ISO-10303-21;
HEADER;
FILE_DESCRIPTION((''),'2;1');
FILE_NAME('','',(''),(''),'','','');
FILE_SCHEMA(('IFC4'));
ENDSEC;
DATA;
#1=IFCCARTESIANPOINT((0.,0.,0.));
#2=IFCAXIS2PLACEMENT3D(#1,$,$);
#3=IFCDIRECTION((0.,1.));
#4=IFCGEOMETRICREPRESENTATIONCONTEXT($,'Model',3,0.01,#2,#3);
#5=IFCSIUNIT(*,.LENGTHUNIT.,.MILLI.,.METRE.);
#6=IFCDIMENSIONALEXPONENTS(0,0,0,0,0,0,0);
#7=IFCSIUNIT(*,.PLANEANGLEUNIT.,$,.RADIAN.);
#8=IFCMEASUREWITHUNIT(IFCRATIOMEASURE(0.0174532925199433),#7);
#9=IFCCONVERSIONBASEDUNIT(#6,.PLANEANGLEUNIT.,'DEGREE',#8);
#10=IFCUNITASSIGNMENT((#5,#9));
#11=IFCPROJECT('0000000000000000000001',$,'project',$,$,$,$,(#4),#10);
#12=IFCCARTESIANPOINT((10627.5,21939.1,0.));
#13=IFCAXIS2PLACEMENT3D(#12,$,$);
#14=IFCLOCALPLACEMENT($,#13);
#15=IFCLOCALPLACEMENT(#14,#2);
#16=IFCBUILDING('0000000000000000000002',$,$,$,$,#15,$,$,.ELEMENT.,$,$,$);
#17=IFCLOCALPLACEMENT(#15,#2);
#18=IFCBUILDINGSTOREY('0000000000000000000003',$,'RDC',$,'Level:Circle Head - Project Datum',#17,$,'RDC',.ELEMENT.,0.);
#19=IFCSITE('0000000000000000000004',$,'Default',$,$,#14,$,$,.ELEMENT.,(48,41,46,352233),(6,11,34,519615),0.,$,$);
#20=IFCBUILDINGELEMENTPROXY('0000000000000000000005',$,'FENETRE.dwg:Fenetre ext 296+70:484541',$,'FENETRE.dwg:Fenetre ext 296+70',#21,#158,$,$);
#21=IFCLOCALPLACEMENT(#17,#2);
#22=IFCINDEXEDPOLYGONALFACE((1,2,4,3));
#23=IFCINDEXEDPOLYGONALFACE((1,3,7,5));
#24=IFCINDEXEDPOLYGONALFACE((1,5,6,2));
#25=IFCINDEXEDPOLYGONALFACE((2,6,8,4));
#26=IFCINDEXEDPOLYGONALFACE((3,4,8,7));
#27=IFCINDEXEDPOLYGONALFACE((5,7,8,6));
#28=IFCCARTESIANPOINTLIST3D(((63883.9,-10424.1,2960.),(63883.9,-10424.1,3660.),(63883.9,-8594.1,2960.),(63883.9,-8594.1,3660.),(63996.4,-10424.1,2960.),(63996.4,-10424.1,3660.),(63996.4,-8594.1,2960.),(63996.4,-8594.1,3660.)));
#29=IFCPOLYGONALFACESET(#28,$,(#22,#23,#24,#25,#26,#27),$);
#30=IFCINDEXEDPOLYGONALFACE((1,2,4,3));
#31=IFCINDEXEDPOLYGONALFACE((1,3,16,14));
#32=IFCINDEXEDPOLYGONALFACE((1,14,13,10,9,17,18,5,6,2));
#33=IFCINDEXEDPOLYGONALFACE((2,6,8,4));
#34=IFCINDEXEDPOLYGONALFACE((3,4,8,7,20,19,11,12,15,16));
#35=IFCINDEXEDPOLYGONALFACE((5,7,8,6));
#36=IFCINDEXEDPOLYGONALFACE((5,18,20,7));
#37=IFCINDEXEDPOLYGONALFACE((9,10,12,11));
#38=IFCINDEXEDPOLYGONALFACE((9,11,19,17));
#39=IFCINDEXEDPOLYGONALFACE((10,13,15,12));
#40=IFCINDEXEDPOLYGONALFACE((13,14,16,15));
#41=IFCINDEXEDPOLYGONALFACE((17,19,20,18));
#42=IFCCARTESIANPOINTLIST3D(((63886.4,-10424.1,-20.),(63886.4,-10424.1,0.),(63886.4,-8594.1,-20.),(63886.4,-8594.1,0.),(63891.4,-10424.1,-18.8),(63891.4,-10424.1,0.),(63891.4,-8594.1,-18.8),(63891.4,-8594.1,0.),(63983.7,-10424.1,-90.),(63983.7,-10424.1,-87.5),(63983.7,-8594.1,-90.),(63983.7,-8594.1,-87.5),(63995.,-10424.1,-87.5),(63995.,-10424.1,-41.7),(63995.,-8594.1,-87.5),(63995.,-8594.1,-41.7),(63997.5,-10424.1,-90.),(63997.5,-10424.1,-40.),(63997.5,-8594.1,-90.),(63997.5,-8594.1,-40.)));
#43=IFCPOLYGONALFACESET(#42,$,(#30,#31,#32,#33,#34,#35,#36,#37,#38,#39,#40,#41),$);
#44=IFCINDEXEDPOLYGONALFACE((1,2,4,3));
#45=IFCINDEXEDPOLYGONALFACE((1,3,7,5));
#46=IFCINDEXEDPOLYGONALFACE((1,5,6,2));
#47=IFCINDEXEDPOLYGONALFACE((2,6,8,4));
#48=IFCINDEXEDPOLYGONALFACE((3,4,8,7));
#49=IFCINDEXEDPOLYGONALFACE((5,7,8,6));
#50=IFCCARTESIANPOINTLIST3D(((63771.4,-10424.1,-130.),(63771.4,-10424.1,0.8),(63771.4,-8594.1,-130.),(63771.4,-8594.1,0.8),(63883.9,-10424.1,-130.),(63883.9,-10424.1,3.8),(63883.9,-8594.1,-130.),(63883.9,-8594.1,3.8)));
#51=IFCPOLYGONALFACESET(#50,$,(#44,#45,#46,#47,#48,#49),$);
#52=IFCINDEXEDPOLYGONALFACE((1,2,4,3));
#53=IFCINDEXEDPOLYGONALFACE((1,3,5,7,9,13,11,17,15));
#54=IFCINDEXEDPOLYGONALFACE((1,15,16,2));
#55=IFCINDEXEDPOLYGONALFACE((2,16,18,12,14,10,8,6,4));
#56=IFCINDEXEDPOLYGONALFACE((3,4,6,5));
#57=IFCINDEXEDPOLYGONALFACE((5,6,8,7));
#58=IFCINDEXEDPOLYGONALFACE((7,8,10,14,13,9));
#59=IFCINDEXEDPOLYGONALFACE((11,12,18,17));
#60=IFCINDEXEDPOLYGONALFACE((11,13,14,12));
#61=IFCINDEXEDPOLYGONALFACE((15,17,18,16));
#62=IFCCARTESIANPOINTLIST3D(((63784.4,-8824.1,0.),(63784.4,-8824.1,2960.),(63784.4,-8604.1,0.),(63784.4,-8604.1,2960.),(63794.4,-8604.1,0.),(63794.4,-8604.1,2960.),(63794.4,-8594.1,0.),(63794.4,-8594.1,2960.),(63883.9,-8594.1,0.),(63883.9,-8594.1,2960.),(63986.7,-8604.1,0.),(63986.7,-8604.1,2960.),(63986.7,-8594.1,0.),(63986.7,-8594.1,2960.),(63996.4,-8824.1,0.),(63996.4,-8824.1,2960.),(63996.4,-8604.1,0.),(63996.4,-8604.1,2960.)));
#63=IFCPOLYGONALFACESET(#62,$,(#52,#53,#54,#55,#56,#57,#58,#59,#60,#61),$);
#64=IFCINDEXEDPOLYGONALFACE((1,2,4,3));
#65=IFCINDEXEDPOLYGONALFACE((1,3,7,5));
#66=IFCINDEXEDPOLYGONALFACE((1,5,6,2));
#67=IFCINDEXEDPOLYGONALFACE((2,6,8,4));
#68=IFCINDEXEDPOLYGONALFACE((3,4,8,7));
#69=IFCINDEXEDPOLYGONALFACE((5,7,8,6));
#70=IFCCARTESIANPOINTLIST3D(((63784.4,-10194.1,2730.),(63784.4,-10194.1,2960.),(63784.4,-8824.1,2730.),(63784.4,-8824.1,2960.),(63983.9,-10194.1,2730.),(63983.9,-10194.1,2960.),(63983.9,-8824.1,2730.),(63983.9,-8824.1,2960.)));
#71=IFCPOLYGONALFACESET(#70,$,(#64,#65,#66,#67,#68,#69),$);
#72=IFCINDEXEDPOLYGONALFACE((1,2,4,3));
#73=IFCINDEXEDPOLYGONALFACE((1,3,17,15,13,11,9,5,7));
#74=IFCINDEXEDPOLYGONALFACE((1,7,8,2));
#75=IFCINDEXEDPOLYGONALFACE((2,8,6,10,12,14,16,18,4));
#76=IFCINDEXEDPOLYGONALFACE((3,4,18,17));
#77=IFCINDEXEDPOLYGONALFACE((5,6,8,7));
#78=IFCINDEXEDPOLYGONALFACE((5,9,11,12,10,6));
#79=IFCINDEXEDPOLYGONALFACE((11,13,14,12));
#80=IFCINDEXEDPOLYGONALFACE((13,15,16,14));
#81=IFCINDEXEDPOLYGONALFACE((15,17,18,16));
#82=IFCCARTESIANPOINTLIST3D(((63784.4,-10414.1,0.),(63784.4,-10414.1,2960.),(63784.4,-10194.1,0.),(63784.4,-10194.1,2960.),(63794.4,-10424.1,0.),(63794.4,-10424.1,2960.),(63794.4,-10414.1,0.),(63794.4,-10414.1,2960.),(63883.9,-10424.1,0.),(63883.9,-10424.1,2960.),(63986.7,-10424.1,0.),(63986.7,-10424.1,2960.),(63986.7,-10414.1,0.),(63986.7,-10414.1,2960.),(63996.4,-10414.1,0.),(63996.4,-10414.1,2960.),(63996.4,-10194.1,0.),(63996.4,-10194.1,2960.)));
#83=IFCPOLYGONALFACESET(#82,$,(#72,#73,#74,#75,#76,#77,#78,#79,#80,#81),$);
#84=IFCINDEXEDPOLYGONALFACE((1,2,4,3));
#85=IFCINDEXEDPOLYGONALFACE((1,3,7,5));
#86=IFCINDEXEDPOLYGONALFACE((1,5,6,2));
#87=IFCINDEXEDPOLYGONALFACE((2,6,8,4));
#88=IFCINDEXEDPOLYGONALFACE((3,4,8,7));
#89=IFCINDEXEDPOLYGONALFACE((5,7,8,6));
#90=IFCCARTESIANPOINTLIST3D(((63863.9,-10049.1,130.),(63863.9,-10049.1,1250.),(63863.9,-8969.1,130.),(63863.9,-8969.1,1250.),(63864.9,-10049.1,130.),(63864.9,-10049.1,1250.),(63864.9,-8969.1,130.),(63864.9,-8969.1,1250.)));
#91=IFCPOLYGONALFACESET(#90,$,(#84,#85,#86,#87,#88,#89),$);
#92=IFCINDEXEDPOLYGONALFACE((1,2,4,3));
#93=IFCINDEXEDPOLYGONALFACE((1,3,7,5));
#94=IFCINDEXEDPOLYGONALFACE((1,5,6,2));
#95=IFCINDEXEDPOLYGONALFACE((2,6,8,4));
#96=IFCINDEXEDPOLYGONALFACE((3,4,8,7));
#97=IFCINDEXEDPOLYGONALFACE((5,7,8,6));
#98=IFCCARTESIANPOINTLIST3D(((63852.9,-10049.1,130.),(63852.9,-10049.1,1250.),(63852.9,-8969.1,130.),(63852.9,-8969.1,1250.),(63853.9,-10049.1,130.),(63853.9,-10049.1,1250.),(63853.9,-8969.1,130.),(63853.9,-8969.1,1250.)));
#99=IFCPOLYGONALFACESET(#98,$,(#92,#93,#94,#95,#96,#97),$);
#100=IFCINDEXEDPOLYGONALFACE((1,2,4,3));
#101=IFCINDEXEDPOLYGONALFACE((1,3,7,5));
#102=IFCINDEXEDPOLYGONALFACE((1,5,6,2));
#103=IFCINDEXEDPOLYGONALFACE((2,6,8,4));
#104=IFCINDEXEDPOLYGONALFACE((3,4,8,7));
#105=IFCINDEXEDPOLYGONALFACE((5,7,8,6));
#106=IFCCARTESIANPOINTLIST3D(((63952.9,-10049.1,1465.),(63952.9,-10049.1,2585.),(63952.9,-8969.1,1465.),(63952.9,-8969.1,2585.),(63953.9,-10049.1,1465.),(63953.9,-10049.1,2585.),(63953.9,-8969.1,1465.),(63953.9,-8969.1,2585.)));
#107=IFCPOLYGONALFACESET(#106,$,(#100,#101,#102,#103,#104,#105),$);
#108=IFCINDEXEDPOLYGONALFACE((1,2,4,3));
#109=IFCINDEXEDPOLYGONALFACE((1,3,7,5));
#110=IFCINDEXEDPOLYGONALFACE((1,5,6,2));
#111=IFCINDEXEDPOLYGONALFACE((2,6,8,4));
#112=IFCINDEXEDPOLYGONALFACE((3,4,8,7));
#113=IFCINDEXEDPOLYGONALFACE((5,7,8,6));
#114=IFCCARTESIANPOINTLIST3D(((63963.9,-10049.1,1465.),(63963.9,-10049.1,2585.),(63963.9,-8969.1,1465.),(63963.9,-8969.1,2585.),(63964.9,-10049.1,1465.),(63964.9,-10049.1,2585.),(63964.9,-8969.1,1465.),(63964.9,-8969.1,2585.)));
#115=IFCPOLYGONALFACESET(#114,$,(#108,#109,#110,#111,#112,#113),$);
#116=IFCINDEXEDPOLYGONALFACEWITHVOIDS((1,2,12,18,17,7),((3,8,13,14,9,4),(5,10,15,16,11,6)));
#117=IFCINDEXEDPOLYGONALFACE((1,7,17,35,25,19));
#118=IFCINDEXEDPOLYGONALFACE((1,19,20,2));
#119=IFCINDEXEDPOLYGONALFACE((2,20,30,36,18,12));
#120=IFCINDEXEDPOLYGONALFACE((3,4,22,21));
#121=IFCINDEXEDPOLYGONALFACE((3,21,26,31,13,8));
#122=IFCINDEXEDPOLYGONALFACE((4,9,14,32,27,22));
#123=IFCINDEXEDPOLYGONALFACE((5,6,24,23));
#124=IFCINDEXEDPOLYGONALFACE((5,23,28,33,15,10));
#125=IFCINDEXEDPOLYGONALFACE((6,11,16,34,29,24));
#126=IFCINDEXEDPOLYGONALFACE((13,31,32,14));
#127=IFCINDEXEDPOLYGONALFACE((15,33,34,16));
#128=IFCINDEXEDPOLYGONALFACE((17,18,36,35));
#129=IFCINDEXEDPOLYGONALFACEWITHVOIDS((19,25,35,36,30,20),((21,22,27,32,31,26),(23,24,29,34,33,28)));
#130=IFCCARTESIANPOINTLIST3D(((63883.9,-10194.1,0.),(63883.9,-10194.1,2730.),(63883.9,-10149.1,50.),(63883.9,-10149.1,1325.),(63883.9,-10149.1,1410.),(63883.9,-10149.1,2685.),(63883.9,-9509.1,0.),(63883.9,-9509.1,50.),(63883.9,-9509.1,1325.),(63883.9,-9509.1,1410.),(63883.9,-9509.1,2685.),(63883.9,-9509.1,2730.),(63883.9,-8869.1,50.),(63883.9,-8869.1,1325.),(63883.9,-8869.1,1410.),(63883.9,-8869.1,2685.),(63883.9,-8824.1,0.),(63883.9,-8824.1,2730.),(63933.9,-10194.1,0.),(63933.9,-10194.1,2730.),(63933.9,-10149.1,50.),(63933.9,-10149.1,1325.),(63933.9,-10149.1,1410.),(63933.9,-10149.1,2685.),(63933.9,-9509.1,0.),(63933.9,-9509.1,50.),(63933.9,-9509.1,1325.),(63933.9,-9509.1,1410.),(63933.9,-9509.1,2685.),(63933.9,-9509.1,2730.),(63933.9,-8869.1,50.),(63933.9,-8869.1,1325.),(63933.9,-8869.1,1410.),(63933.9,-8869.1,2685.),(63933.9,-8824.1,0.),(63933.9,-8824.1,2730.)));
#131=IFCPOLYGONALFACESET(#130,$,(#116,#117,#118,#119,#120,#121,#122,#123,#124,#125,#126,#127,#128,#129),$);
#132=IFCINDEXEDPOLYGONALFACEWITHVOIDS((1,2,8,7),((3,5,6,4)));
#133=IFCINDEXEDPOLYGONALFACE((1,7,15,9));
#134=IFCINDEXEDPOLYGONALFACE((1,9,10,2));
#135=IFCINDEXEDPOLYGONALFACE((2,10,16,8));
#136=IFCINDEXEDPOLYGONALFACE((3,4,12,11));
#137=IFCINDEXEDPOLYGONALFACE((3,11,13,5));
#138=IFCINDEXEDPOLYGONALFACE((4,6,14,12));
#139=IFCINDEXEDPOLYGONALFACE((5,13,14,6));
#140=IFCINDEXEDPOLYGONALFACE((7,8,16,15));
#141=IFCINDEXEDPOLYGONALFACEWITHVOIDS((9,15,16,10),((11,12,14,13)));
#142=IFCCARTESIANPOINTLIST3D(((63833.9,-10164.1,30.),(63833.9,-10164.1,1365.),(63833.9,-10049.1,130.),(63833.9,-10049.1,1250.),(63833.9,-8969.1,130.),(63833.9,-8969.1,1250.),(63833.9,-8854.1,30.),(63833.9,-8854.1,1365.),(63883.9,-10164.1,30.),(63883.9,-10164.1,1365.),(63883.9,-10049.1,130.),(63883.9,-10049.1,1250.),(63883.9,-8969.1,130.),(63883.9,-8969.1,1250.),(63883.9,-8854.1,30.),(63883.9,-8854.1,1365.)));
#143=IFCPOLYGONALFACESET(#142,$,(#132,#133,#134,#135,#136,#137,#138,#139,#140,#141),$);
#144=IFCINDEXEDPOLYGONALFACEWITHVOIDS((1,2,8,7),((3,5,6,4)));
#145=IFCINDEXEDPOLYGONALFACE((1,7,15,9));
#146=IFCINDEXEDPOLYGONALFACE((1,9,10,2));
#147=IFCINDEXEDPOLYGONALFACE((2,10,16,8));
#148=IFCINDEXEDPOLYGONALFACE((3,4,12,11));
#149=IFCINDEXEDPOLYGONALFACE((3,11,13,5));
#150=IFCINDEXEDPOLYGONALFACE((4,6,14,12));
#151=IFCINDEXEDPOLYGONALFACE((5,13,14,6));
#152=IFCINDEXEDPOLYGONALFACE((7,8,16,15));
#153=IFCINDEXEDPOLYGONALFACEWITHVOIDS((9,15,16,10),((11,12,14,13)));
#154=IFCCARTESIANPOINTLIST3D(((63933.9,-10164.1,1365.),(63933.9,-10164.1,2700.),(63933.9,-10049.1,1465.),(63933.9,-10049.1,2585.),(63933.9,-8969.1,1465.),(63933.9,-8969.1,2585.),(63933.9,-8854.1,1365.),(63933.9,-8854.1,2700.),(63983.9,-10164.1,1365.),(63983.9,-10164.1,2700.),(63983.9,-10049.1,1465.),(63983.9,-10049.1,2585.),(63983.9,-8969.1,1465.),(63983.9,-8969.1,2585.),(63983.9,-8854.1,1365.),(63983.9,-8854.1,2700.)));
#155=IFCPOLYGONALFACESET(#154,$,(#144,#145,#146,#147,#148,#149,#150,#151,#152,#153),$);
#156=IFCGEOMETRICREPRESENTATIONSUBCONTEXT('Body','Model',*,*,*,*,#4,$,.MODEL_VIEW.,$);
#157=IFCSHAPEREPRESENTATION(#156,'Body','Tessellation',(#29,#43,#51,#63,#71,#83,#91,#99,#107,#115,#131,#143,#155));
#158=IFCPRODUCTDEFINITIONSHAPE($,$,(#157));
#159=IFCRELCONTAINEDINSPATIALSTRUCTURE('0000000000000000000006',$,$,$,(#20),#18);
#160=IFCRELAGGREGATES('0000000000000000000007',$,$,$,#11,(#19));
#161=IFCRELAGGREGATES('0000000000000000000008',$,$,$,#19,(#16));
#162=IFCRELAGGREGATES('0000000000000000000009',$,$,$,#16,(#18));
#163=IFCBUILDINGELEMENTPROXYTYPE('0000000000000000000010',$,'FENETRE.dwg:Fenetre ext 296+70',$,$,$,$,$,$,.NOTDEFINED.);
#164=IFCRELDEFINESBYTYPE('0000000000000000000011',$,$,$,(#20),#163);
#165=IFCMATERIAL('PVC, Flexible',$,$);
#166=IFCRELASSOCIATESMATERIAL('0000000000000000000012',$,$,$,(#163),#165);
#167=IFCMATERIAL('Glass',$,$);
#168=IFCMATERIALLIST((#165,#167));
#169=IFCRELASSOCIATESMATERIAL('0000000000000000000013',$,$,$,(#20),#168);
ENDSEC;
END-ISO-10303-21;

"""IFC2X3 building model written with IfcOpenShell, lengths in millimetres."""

from ifc_helpers import new_model, entity, si_unit, converted_unit, direction, frame, frame_2d, origin, origin_2d_with_axis, place, context, subcontext, project, spatial, polyline, rectangle, outline, extrude, source, transform, mapped, material, material_list, type_object, type_shapes, element, save


model = new_model("IFC2X3")

# Units and contexts
model_context = context("Model", 3, precision=0.01, world=origin(), true_north=direction((0.0, 1.0)))
body_context = subcontext(model_context, "Body", "Model", "MODEL_VIEW")
ifc_project = project(units=[si_unit("LENGTHUNIT", "METRE", prefix="MILLI"), converted_unit("PLANEANGLEUNIT", "DEGREE", entity("IfcRatioMeasure", 0.0174532925199433), si_unit("PLANEANGLEUNIT", "RADIAN"), dimensions=[0, 0, 0, 0, 0, 0, 0])], contexts=[model_context])

# Site, building, storey
site_placement = place(None, frame((10627.5, 21939.1, 0.0)))
site = spatial("IfcSite", under=ifc_project, at=site_placement, Name="Default", CompositionType="ELEMENT", RefLatitude=(48, 41, 46, 352233), RefLongitude=(6, 11, 34, 519615), RefElevation=0.0)
building_placement = place(site_placement, origin())
building = spatial("IfcBuilding", under=site, at=building_placement, CompositionType="ELEMENT")
storey_placement = place(building_placement, origin())
storey = spatial("IfcBuildingStorey", under=building, at=storey_placement, Name="RDC", ObjectType="Level:Circle Head - Project Datum", LongName="RDC", CompositionType="ELEMENT", Elevation=0.0)

# Building element proxy
ifc_material_1 = material(Name="PVC, Flexible")
ifc_material_2 = material(Name="Glass")
building_element_proxy_type_1 = type_object("IfcBuildingElementProxyType", Name="FENETRE.dwg:Fenetre ext 296+70", PredefinedType="NOTDEFINED", material=ifc_material_1)
shared_shape_1 = source(origin(), body_context, "Body", "SweptSolid", [
    extrude(rectangle(XDim=112.5, YDim=1830.0, at=origin_2d_with_axis()), frame((-10.4, -56.3, 2960.0), z_axis=(0.0, 0.0, 1.0), x_axis=(0.0, 1.0, 0.0)), (0.0, 0.0, 1.0), 700.0),
    extrude(outline(polyline([(27.5, -64.4), (47.5, -64.4), (47.5, -59.4), (28.8, -59.4), (7.5, 46.7), (-42.5, 46.7), (-42.5, 32.9), (-40.0, 32.9), (-40.0, 44.2), (5.8, 44.2), (27.5, -64.4)])), frame((-925.4, -66.9, -47.5), z_axis=(1.0, 0.0, 0.0), x_axis=(0.0, 0.0, 1.0)), (0.0, 0.0, 1.0), 1830.0),
    extrude(outline(polyline([(-54.5, -66.1), (58.0, -66.1), (54.5, 67.6), (-58.0, 64.6), (-54.5, -66.1)])), frame((-925.4, 56.3, -63.8), z_axis=(1.0, 0.0, 0.0), x_axis=(0.0, -0.999645, 0.02665)), (0.0, 0.0, 1.0), 1830.0),
    extrude(outline(polyline([(-97.0, -55.6), (5.9, -55.6), (95.4, -55.6), (95.4, -45.6), (105.4, -45.6), (105.4, 174.4), (-106.6, 174.4), (-106.6, -45.6), (-97.0, -45.6), (-97.0, -55.6)])), frame((849.0, -5.9, 0.0), z_axis=(0.0, 0.0, 1.0), x_axis=(0.0, 1.0, 0.0)), (0.0, 0.0, 1.0), 2960.0),
    extrude(rectangle(XDim=1370.0, YDim=199.5, at=origin_2d_with_axis()), frame((-10.4, -0.3, 2730.0), z_axis=(0.0, 0.0, 1.0), x_axis=(-1.0, 0.0, 0.0)), (0.0, 0.0, 1.0), 230.0),
    extrude(outline(polyline([(-55.6, 97.0), (-55.6, -5.9), (-55.6, -95.4), (-45.6, -95.4), (-45.6, -105.4), (174.4, -105.4), (174.4, 106.6), (-45.6, 106.6), (-45.6, 97.0), (-55.6, 97.0)])), frame((-869.9, -5.9, 0.0), z_axis=(0.0, 0.0, -1.0), x_axis=(1.0, 0.0, 0.0)), (0.0, 0.0, -1.0), 2960.0),
    extrude(rectangle(XDim=1080.0, YDim=1.0, at=origin_2d_with_axis()), frame((-10.4, 19.5, 130.0), z_axis=(0.0, 0.0, 1.0), x_axis=(-1.0, 0.0, 0.0)), (0.0, 0.0, 1.0), 1120.0),
    extrude(rectangle(XDim=1080.0, YDim=1.0, at=origin_2d_with_axis()), frame((-10.4, 30.5, 130.0), z_axis=(0.0, 0.0, 1.0), x_axis=(-1.0, 0.0, 0.0)), (0.0, 0.0, 1.0), 1120.0),
    extrude(rectangle(XDim=1080.0, YDim=1.0, at=frame_2d((0.0, 0.0), x_axis=(1.0, 0.0))), frame((-10.4, -69.5, 1465.0), z_axis=(0.0, 0.0, 1.0), x_axis=(-1.0, 0.0, 0.0)), (0.0, 0.0, 1.0), 1120.0),
    extrude(rectangle(XDim=1080.0, YDim=1.0, at=frame_2d((0.0, 0.0), x_axis=(1.0, 0.0))), frame((-10.4, -80.5, 1465.0), z_axis=(0.0, 0.0, 1.0), x_axis=(-1.0, 0.0, 0.0)), (0.0, 0.0, 1.0), 1120.0),
    extrude(outline(polyline([(-685.0, -1365.0), (0.0, -1365.0), (685.0, -1365.0), (685.0, 1365.0), (0.0, 1365.0), (-685.0, 1365.0), (-685.0, -1365.0)]), holes=[polyline([(-640.0, -1320.0), (-640.0, -45.0), (0.0, -45.0), (640.0, -45.0), (640.0, -1320.0), (0.0, -1320.0), (-640.0, -1320.0)]), polyline([(-640.0, 40.0), (-640.0, 1315.0), (0.0, 1315.0), (640.0, 1315.0), (640.0, 40.0), (0.0, 40.0), (-640.0, 40.0)])]), frame((-10.4, -50.0, 1365.0), z_axis=(0.0, 1.0, 0.0), x_axis=(1.0, 0.0, 0.0)), (0.0, 0.0, 1.0), 50.0),
    extrude(outline(polyline([(-655.0, -667.5), (655.0, -667.5), (655.0, 667.5), (-655.0, 667.5), (-655.0, -667.5)]), holes=[polyline([(-540.0, 552.5), (540.0, 552.5), (540.0, -567.5), (-540.0, -567.5), (-540.0, 552.5)])]), frame((-10.4, 0.0, 697.5), z_axis=(0.0, 1.0, 0.0), x_axis=(-1.0, 0.0, 0.0)), (0.0, 0.0, 1.0), 50.0),
    extrude(outline(polyline([(-655.0, -667.5), (655.0, -667.5), (655.0, 667.5), (-655.0, 667.5), (-655.0, -667.5)]), holes=[polyline([(-540.0, 552.5), (540.0, 552.5), (540.0, -567.5), (-540.0, -567.5), (-540.0, 552.5)])]), frame((-10.4, -100.0, 2032.5), z_axis=(0.0, 1.0, 0.0), x_axis=(-1.0, 0.0, 0.0)), (0.0, 0.0, 1.0), 50.0),
])
type_shapes(building_element_proxy_type_1, [shared_shape_1])
ifc_material_list_1 = material_list([ifc_material_1, ifc_material_2])
proxy_1_placement = place(storey_placement, frame((63883.9, -9498.7, 0.0), z_axis=(0.0, 0.0, 1.0), x_axis=(0.0, 1.0, 0.0)))
element("IfcBuildingElementProxy", 1, at=proxy_1_placement, inside=storey, type_object=building_element_proxy_type_1, material=ifc_material_list_1, Name="FENETRE.dwg:Fenetre ext 296+70:484541", ObjectType="FENETRE.dwg:Fenetre ext 296+70", context=body_context, shape_type="MappedRepresentation", body=[
    mapped(shared_shape_1, transform((0.0, 0.0, 0.0), scale=1.0)),
])

save(model, "model.ifc")
